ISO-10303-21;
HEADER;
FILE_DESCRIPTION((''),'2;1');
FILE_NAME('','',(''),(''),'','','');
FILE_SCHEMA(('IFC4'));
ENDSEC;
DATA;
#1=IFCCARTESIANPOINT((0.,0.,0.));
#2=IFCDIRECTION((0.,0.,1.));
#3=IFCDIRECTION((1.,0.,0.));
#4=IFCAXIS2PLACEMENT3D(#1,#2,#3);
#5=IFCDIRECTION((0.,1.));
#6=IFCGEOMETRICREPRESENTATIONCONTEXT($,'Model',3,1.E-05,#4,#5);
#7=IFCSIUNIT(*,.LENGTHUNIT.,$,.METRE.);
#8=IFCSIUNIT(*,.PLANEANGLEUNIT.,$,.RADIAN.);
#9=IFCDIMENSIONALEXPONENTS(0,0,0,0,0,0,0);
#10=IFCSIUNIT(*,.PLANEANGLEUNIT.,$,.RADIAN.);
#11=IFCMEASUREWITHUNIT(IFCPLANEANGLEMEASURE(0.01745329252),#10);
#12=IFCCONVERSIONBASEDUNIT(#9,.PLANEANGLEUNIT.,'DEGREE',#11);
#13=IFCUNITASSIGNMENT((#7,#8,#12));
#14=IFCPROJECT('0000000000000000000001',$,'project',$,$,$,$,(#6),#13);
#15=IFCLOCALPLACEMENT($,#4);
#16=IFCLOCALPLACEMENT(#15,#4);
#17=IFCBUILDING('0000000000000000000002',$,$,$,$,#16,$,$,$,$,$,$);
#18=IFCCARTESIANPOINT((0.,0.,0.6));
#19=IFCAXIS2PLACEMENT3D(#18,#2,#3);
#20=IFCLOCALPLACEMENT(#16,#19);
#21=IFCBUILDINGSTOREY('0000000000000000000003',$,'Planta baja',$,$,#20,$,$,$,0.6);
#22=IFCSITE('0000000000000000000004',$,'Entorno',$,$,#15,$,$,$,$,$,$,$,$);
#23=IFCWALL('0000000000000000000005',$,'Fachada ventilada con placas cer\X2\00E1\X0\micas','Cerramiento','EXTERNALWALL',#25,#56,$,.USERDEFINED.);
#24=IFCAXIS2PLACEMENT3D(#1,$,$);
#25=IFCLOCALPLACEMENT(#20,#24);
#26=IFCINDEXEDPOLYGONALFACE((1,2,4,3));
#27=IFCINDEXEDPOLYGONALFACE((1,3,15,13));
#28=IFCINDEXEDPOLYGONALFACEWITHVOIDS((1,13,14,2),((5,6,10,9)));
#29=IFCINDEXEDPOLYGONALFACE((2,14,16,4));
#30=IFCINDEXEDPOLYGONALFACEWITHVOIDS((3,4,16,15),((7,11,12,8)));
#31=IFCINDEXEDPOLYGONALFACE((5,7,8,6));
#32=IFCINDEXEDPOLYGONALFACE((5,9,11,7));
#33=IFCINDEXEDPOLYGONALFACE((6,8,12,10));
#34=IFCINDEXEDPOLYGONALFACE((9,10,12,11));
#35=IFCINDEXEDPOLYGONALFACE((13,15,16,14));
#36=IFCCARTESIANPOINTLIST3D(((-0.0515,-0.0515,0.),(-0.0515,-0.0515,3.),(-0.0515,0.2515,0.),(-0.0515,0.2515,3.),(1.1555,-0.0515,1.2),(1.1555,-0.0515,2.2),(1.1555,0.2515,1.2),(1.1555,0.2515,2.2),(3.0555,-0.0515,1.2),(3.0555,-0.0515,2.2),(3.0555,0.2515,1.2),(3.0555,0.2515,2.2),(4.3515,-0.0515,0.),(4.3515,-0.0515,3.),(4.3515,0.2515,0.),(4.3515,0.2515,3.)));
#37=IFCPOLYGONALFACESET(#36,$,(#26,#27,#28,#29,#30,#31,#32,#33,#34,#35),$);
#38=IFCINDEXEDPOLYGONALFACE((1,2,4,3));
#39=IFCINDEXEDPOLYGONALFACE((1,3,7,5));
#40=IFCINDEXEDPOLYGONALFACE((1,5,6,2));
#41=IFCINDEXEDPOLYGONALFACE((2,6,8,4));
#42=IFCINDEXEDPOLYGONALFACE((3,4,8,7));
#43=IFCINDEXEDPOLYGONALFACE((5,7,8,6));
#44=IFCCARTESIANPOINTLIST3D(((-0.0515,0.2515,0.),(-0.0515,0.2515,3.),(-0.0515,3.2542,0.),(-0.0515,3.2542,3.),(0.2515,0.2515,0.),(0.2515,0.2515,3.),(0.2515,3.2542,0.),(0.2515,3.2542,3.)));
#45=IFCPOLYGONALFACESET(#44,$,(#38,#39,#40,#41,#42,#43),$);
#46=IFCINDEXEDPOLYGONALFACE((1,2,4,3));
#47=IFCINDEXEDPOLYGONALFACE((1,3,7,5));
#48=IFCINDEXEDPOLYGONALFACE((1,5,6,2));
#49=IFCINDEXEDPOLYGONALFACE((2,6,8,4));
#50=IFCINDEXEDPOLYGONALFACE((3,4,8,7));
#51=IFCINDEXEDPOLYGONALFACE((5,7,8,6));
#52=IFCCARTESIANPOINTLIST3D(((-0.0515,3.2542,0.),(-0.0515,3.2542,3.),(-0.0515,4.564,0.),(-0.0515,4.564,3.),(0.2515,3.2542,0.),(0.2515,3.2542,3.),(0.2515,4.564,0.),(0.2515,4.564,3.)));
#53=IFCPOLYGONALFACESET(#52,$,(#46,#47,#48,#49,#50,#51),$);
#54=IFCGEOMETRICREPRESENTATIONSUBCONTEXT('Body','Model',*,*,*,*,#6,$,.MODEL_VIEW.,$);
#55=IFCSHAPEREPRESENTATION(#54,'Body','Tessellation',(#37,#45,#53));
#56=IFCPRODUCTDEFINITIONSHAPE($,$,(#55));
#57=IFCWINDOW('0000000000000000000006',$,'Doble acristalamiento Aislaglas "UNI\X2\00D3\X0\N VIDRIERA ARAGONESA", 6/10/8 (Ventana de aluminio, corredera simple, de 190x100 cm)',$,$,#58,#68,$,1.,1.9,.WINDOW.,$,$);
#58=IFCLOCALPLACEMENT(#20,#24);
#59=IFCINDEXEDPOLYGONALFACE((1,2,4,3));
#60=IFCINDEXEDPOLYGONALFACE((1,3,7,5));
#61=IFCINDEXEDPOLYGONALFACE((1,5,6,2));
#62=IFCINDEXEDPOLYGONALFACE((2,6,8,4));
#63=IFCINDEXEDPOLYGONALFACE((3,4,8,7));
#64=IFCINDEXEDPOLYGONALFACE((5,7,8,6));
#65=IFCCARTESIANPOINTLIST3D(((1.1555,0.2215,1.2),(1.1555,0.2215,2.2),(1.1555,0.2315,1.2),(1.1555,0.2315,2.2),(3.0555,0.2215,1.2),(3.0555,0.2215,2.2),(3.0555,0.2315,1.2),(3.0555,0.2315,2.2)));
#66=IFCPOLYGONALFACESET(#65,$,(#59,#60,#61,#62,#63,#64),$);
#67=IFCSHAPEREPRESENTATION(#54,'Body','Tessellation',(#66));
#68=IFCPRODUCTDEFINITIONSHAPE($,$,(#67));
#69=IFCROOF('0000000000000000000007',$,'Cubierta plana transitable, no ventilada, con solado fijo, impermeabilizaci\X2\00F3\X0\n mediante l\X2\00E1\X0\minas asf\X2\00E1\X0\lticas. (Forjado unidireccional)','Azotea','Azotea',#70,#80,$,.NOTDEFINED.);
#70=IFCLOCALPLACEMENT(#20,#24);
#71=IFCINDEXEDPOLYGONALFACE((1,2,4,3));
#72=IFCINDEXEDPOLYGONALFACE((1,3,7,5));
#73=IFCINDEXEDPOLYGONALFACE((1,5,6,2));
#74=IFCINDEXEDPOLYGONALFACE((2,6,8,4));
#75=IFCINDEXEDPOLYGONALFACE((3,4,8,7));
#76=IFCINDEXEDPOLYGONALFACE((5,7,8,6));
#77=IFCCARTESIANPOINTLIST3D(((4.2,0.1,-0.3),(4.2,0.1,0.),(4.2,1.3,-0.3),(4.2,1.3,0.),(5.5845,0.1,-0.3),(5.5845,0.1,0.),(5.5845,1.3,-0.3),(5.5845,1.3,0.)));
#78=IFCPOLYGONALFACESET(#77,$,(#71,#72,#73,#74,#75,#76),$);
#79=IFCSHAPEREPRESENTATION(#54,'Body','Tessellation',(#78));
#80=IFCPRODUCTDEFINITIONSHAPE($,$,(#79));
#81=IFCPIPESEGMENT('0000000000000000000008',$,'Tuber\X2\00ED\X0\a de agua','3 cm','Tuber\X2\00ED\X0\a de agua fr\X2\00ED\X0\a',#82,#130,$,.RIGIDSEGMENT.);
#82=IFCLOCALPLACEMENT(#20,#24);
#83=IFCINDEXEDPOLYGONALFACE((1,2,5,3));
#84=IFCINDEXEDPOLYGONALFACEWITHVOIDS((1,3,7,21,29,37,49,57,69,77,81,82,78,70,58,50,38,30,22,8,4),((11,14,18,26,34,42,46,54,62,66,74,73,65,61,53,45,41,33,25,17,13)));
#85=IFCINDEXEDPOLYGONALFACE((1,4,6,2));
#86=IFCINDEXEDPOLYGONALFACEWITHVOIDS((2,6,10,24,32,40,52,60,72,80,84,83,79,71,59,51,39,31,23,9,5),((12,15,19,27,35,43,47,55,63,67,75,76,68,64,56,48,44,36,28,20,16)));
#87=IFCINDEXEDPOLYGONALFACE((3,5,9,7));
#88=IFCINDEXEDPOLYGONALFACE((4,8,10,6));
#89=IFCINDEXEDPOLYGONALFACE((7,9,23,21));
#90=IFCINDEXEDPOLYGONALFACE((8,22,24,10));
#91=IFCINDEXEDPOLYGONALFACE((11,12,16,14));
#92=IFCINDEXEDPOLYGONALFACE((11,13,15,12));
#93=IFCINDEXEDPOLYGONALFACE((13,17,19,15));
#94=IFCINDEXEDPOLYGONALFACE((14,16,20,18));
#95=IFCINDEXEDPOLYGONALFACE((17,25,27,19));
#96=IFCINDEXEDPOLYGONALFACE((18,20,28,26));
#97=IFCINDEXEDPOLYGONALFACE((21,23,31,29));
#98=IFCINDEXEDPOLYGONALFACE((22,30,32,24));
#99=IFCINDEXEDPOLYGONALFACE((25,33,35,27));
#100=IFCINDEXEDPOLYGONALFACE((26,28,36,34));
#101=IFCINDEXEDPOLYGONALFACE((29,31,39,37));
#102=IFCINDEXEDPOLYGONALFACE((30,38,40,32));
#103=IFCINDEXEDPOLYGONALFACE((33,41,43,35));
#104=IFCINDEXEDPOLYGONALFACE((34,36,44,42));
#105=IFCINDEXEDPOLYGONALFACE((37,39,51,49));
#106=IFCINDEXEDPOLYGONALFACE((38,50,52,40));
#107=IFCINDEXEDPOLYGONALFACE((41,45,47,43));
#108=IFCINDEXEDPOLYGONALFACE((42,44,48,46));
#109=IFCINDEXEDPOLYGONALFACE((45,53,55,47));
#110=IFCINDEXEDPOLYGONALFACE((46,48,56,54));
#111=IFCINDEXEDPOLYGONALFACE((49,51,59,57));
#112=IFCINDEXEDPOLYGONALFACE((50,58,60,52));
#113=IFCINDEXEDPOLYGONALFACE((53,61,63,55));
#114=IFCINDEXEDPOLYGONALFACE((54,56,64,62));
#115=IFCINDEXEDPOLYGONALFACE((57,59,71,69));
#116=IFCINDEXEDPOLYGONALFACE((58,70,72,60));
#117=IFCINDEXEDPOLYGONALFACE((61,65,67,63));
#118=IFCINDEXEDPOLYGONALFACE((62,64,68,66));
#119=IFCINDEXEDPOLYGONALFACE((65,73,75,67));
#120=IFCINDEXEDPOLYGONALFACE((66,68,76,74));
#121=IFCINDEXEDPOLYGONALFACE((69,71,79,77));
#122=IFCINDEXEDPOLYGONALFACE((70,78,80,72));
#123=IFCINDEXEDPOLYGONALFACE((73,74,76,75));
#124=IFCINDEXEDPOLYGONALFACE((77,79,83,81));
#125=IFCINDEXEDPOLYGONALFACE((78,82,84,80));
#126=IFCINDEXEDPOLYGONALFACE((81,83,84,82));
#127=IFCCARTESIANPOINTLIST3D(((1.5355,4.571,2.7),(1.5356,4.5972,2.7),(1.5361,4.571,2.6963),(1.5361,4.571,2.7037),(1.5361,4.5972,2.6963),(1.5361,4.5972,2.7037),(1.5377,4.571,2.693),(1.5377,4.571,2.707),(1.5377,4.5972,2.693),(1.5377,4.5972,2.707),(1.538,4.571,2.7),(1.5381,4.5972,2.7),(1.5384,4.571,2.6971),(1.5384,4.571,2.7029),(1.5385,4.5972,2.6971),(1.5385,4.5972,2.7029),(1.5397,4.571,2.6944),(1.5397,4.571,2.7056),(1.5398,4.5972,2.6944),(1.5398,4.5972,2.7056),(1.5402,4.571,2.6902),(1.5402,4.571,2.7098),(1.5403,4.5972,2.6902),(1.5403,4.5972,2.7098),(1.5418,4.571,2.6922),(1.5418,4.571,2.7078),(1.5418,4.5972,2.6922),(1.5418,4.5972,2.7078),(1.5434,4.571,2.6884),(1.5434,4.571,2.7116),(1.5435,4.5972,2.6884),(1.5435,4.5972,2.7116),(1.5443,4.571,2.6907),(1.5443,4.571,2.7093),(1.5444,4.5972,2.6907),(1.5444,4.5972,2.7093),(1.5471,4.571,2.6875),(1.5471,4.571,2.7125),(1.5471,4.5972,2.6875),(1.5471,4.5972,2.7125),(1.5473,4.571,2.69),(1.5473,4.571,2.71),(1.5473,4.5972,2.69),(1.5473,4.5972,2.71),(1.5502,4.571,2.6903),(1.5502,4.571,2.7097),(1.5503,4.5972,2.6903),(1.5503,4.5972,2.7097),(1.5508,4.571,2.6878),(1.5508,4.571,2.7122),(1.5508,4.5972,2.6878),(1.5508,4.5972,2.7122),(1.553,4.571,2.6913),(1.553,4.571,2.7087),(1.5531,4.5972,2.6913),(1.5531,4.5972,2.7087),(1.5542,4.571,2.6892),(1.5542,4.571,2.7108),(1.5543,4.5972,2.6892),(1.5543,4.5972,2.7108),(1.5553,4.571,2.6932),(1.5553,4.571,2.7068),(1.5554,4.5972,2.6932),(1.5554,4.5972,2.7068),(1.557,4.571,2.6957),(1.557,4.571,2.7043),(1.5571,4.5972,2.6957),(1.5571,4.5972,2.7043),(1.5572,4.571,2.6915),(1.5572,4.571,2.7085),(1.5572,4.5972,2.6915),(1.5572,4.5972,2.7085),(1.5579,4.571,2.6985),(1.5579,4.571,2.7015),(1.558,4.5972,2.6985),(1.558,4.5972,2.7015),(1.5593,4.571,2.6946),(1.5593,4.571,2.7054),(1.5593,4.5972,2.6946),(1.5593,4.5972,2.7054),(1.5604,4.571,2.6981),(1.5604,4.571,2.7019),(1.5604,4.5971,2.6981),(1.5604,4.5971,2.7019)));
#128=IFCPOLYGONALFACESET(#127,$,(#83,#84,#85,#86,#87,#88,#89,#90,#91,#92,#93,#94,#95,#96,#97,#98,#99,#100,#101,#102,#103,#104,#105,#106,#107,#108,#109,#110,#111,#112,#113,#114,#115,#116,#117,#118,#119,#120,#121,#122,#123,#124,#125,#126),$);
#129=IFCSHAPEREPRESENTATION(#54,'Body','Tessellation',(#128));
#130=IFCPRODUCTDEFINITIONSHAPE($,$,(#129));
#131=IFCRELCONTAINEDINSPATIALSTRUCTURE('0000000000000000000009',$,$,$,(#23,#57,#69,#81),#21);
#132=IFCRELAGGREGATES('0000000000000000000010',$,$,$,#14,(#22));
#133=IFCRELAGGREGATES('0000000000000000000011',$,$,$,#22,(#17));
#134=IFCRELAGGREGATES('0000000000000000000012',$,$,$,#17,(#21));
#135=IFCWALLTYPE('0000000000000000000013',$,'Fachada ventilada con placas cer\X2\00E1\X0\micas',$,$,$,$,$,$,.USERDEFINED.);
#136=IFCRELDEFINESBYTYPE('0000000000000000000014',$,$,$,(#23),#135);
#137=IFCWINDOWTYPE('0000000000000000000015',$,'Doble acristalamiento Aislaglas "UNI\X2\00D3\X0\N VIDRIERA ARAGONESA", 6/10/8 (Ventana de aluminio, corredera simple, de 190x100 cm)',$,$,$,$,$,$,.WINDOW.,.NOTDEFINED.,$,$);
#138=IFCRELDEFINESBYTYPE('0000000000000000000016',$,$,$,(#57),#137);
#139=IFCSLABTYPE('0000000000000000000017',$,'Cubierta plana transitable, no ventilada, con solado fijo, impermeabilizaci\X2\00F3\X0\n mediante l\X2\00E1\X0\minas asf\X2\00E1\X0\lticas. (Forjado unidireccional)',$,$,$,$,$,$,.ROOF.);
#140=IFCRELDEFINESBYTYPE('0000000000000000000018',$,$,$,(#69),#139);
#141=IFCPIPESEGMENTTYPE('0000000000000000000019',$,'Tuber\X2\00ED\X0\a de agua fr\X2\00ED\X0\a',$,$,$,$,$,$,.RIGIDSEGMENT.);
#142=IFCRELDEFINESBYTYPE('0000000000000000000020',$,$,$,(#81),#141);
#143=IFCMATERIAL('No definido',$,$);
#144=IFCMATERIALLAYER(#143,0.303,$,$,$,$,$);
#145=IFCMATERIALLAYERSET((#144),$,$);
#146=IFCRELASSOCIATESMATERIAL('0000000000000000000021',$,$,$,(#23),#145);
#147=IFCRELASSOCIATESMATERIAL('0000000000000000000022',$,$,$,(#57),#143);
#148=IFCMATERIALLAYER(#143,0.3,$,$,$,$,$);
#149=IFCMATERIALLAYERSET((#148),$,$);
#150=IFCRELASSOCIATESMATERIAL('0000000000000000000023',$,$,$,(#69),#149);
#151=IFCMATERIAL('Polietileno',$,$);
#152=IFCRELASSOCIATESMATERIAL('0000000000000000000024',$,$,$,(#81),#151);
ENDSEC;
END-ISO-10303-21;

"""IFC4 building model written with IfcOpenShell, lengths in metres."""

from ifc_helpers import new_model, entity, si_unit, converted_unit, direction, frame, origin_with_axes, origin_2d_with_axis, place, context, subcontext, project, spatial, polyline, rectangle, hollow_circle, outline, extrude, shape, material, layer, layer_set, layer_usage, type_object, element, fill, save


model = new_model("IFC4")

# Units and contexts
model_context = context("Model", 3, precision=1e-05, world=origin_with_axes(), true_north=direction((0.0, 1.0)))
body_context = subcontext(model_context, "Body", "Model", "MODEL_VIEW")
footprint_context = subcontext(model_context, "FootPrint", "Model", "MODEL_VIEW")
ifc_project = project(units=[si_unit("LENGTHUNIT", "METRE"), si_unit("PLANEANGLEUNIT", "RADIAN"), converted_unit("PLANEANGLEUNIT", "DEGREE", entity("IfcPlaneAngleMeasure", 0.01745329252), si_unit("PLANEANGLEUNIT", "RADIAN"), dimensions=[0, 0, 0, 0, 0, 0, 0])], contexts=[model_context])

# Site, building, storey
site_placement = place(None, origin_with_axes())
site = spatial("IfcSite", under=ifc_project, at=site_placement, Name="Entorno")
building_placement = place(site_placement, origin_with_axes())
building = spatial("IfcBuilding", under=site, at=building_placement)
storey_placement = place(building_placement, frame((0.0, 0.0, 0.6), z_axis=(0.0, 0.0, 1.0), x_axis=(1.0, 0.0, 0.0)))
storey = spatial("IfcBuildingStorey", under=building, at=storey_placement, Name="Planta baja", Elevation=0.6)

# Shared definitions
ifc_material_1 = material(Name="No definido")

# Shared definitions
wall_type_1 = type_object("IfcWallType", Name="Fachada ventilada con placas cerámicas", PredefinedType="USERDEFINED")

# Wall, opening, window
ifc_layer_1 = layer(ifc_material_1, 0.303)
ifc_layer_set_1 = layer_set([ifc_layer_1])
ifc_layer_usage_1 = layer_usage(ifc_layer_set_1, "AXIS2", "POSITIVE", -0.1515)
wall_1_placement = place(storey_placement, frame((4.2, 0.1, 0.0), z_axis=(0.0, 0.0, 1.0), x_axis=(-1.0, 0.0, 0.0)))
cartesian_point_1 = entity("IfcCartesianPoint", [-2.2015, -1.5])
cartesian_point_2 = entity("IfcCartesianPoint", [-2.2015, -1.5])
cartesian_point_3 = entity("IfcCartesianPoint", [-1.5013, -1.5])
cartesian_point_4 = entity("IfcCartesianPoint", [-1.5013, -1.5])
cartesian_point_5 = entity("IfcCartesianPoint", [-0.6549, -1.5])
cartesian_point_6 = entity("IfcCartesianPoint", [-0.6549, -1.5])
wall_1 = element("IfcWall", 1, at=wall_1_placement, inside=storey, type_object=wall_type_1, material=ifc_layer_usage_1, Name="Fachada ventilada con placas cerámicas", Description="Cerramiento", ObjectType="EXTERNALWALL", PredefinedType="USERDEFINED", context=body_context, shape_type="SolidModel", body=[
    entity("IfcExtrudedAreaSolidTapered", entity("IfcArbitraryClosedProfileDef", "AREA", None, entity("IfcPolyline", [cartesian_point_1, entity("IfcCartesianPoint", [2.2015, -1.5]), entity("IfcCartesianPoint", [2.2015, 1.5]), entity("IfcCartesianPoint", [-2.2015, 1.5]), cartesian_point_1])), entity("IfcAxis2Placement3D", entity("IfcCartesianPoint", [2.05, 0.1515, 1.5]), entity("IfcDirection", [0.0, -1.0, 0.0]), entity("IfcDirection", [1.0, 0.0, 0.0])), entity("IfcDirection", [0.0, 0.0, 1.0]), 0.303, entity("IfcArbitraryClosedProfileDef", "AREA", None, entity("IfcPolyline", [cartesian_point_2, entity("IfcCartesianPoint", [2.2015, -1.5]), entity("IfcCartesianPoint", [2.2015, 1.5]), entity("IfcCartesianPoint", [-2.2015, 1.5]), cartesian_point_2]))),
    entity("IfcExtrudedAreaSolidTapered", entity("IfcArbitraryClosedProfileDef", "AREA", None, entity("IfcPolyline", [cartesian_point_3, entity("IfcCartesianPoint", [1.5013, -1.5]), entity("IfcCartesianPoint", [1.5013, 1.5]), entity("IfcCartesianPoint", [-1.5013, 1.5]), cartesian_point_3])), entity("IfcAxis2Placement3D", entity("IfcCartesianPoint", [4.2515, -1.6528, 1.5]), entity("IfcDirection", [-1.0, 0.0, 0.0]), entity("IfcDirection", [0.0, -1.0, 0.0])), entity("IfcDirection", [0.0, 0.0, 1.0]), 0.303, entity("IfcArbitraryClosedProfileDef", "AREA", None, entity("IfcPolyline", [cartesian_point_4, entity("IfcCartesianPoint", [1.5013, -1.5]), entity("IfcCartesianPoint", [1.5013, 1.5]), entity("IfcCartesianPoint", [-1.5013, 1.5]), cartesian_point_4]))),
    entity("IfcExtrudedAreaSolidTapered", entity("IfcArbitraryClosedProfileDef", "AREA", None, entity("IfcPolyline", [cartesian_point_5, entity("IfcCartesianPoint", [0.6549, -1.5]), entity("IfcCartesianPoint", [0.6549, 1.5]), entity("IfcCartesianPoint", [-0.6549, 1.5]), cartesian_point_5])), entity("IfcAxis2Placement3D", entity("IfcCartesianPoint", [4.2515, -3.8091, 1.5]), entity("IfcDirection", [-1.0, 0.0, 0.0]), entity("IfcDirection", [0.0, -1.0, 0.0])), entity("IfcDirection", [0.0, 0.0, 1.0]), 0.303, entity("IfcArbitraryClosedProfileDef", "AREA", None, entity("IfcPolyline", [cartesian_point_6, entity("IfcCartesianPoint", [0.6549, -1.5]), entity("IfcCartesianPoint", [0.6549, 1.5]), entity("IfcCartesianPoint", [-0.6549, 1.5]), cartesian_point_6]))),
])
opening_1_placement = place(wall_1_placement, frame((2.0945, 0.0, 1.7), z_axis=(0.0, 0.0, 1.0), x_axis=(1.0, 0.0, 0.0)))
cartesian_point_7 = entity("IfcCartesianPoint", [-0.95, -0.1515])
opening_1 = element("IfcOpeningElement", 2, at=opening_1_placement, cuts=wall_1, ObjectType="No definido", PredefinedType="OPENING", shapes=[
    shape(body_context, "Body", "SweptSolid", [extrude(rectangle(XDim=1.0, YDim=1.9, at=origin_2d_with_axis()), frame((0.0, -0.1515, 0.0), z_axis=(0.0, 1.0, 0.0), x_axis=(0.0, 0.0, 1.0)), (0.0, 0.0, 1.0), 0.303)]),
    shape(footprint_context, "FootPrint", "GeometricCurveSet", [entity("IfcGeometricCurveSet", [entity("IfcPolyline", [cartesian_point_7, entity("IfcCartesianPoint", [0.95, -0.1515]), entity("IfcCartesianPoint", [0.95, 0.1515]), entity("IfcCartesianPoint", [-0.95, 0.1515]), cartesian_point_7])])]),
])
window_type = type_object("IfcWindowType", Name="Doble acristalamiento Aislaglas \"UNIÓN VIDRIERA ARAGONESA\", 6/10/8 (Ventana de aluminio, corredera simple, de 190x100 cm)", PartitioningType="NOTDEFINED", PredefinedType="WINDOW")
window_placement = place(opening_1_placement, frame((0.0, -0.1265, 0.0), z_axis=(0.0, 0.0, 1.0), x_axis=(1.0, 0.0, 0.0)))
window = element("IfcWindow", 3, at=window_placement, inside=storey, type_object=window_type, material=ifc_material_1, Name="Doble acristalamiento Aislaglas \"UNIÓN VIDRIERA ARAGONESA\", 6/10/8 (Ventana de aluminio, corredera simple, de 190x100 cm)", OverallHeight=1.0, OverallWidth=1.9, PredefinedType="WINDOW", context=body_context, shape_type="SweptSolid", body=[
    extrude(rectangle(XDim=1.9, YDim=1.0, at=origin_2d_with_axis()), frame((0.0, 0.005, 0.0), z_axis=(0.0, -1.0, 0.0), x_axis=(1.0, 0.0, 0.0)), (0.0, 0.0, 1.0), 0.01),
])
fill(opening_1, window)

# Roof
ifc_layer_2 = layer(ifc_material_1, 0.3)
ifc_layer_set_2 = layer_set([ifc_layer_2])
ifc_layer_usage_2 = layer_usage(ifc_layer_set_2, "AXIS3", "POSITIVE", 0.0)
slab_type = type_object("IfcSlabType", Name="Cubierta plana transitable, no ventilada, con solado fijo, impermeabilización mediante láminas asfálticas. (Forjado unidireccional)", PredefinedType="ROOF")
roof_placement = place(storey_placement, frame((5.5845, 0.1, -0.3), z_axis=(0.0, 0.0, 1.0), x_axis=(1.0, 0.0, 0.0)))
element("IfcRoof", 4, at=roof_placement, inside=storey, type_object=slab_type, material=ifc_layer_usage_2, Name="Cubierta plana transitable, no ventilada, con solado fijo, impermeabilización mediante láminas asfálticas. (Forjado unidireccional)", Description="Azotea", ObjectType="Azotea", PredefinedType="NOTDEFINED", context=body_context, shape_type="SweptSolid", body=[
    extrude(outline(polyline([(0.0, 0.0), (0.0, 1.2), (-1.3845, 1.2), (-1.3845, 0.0), (0.0, 0.0)])), origin_with_axes(), (0.0, 0.0, 1.0), 0.3),
])

# Pipe segment
ifc_material_2 = material(Name="Polietileno")
pipe_segment_type_1 = type_object("IfcPipeSegmentType", Name="Tubería de agua fría", PredefinedType="RIGIDSEGMENT")
pipe_segment_1_placement = place(storey_placement, frame((1.548, 4.571, 2.7), z_axis=(0.002419, 0.999997, 0.0), x_axis=(-0.999997, 0.002419, 0.0)))
element("IfcPipeSegment", 5, at=pipe_segment_1_placement, inside=storey, type_object=pipe_segment_type_1, material=ifc_material_2, Name="Tubería de agua", Description="3 cm", ObjectType="Tubería de agua fría", PredefinedType="RIGIDSEGMENT", context=body_context, shape_type="SweptSolid", body=[
    extrude(hollow_circle(Radius=0.0125, WallThickness=0.0025, at=origin_2d_with_axis()), origin_with_axes(), (0.0, 0.0, 1.0), 0.0262),
])

save(model, "model.ifc")
